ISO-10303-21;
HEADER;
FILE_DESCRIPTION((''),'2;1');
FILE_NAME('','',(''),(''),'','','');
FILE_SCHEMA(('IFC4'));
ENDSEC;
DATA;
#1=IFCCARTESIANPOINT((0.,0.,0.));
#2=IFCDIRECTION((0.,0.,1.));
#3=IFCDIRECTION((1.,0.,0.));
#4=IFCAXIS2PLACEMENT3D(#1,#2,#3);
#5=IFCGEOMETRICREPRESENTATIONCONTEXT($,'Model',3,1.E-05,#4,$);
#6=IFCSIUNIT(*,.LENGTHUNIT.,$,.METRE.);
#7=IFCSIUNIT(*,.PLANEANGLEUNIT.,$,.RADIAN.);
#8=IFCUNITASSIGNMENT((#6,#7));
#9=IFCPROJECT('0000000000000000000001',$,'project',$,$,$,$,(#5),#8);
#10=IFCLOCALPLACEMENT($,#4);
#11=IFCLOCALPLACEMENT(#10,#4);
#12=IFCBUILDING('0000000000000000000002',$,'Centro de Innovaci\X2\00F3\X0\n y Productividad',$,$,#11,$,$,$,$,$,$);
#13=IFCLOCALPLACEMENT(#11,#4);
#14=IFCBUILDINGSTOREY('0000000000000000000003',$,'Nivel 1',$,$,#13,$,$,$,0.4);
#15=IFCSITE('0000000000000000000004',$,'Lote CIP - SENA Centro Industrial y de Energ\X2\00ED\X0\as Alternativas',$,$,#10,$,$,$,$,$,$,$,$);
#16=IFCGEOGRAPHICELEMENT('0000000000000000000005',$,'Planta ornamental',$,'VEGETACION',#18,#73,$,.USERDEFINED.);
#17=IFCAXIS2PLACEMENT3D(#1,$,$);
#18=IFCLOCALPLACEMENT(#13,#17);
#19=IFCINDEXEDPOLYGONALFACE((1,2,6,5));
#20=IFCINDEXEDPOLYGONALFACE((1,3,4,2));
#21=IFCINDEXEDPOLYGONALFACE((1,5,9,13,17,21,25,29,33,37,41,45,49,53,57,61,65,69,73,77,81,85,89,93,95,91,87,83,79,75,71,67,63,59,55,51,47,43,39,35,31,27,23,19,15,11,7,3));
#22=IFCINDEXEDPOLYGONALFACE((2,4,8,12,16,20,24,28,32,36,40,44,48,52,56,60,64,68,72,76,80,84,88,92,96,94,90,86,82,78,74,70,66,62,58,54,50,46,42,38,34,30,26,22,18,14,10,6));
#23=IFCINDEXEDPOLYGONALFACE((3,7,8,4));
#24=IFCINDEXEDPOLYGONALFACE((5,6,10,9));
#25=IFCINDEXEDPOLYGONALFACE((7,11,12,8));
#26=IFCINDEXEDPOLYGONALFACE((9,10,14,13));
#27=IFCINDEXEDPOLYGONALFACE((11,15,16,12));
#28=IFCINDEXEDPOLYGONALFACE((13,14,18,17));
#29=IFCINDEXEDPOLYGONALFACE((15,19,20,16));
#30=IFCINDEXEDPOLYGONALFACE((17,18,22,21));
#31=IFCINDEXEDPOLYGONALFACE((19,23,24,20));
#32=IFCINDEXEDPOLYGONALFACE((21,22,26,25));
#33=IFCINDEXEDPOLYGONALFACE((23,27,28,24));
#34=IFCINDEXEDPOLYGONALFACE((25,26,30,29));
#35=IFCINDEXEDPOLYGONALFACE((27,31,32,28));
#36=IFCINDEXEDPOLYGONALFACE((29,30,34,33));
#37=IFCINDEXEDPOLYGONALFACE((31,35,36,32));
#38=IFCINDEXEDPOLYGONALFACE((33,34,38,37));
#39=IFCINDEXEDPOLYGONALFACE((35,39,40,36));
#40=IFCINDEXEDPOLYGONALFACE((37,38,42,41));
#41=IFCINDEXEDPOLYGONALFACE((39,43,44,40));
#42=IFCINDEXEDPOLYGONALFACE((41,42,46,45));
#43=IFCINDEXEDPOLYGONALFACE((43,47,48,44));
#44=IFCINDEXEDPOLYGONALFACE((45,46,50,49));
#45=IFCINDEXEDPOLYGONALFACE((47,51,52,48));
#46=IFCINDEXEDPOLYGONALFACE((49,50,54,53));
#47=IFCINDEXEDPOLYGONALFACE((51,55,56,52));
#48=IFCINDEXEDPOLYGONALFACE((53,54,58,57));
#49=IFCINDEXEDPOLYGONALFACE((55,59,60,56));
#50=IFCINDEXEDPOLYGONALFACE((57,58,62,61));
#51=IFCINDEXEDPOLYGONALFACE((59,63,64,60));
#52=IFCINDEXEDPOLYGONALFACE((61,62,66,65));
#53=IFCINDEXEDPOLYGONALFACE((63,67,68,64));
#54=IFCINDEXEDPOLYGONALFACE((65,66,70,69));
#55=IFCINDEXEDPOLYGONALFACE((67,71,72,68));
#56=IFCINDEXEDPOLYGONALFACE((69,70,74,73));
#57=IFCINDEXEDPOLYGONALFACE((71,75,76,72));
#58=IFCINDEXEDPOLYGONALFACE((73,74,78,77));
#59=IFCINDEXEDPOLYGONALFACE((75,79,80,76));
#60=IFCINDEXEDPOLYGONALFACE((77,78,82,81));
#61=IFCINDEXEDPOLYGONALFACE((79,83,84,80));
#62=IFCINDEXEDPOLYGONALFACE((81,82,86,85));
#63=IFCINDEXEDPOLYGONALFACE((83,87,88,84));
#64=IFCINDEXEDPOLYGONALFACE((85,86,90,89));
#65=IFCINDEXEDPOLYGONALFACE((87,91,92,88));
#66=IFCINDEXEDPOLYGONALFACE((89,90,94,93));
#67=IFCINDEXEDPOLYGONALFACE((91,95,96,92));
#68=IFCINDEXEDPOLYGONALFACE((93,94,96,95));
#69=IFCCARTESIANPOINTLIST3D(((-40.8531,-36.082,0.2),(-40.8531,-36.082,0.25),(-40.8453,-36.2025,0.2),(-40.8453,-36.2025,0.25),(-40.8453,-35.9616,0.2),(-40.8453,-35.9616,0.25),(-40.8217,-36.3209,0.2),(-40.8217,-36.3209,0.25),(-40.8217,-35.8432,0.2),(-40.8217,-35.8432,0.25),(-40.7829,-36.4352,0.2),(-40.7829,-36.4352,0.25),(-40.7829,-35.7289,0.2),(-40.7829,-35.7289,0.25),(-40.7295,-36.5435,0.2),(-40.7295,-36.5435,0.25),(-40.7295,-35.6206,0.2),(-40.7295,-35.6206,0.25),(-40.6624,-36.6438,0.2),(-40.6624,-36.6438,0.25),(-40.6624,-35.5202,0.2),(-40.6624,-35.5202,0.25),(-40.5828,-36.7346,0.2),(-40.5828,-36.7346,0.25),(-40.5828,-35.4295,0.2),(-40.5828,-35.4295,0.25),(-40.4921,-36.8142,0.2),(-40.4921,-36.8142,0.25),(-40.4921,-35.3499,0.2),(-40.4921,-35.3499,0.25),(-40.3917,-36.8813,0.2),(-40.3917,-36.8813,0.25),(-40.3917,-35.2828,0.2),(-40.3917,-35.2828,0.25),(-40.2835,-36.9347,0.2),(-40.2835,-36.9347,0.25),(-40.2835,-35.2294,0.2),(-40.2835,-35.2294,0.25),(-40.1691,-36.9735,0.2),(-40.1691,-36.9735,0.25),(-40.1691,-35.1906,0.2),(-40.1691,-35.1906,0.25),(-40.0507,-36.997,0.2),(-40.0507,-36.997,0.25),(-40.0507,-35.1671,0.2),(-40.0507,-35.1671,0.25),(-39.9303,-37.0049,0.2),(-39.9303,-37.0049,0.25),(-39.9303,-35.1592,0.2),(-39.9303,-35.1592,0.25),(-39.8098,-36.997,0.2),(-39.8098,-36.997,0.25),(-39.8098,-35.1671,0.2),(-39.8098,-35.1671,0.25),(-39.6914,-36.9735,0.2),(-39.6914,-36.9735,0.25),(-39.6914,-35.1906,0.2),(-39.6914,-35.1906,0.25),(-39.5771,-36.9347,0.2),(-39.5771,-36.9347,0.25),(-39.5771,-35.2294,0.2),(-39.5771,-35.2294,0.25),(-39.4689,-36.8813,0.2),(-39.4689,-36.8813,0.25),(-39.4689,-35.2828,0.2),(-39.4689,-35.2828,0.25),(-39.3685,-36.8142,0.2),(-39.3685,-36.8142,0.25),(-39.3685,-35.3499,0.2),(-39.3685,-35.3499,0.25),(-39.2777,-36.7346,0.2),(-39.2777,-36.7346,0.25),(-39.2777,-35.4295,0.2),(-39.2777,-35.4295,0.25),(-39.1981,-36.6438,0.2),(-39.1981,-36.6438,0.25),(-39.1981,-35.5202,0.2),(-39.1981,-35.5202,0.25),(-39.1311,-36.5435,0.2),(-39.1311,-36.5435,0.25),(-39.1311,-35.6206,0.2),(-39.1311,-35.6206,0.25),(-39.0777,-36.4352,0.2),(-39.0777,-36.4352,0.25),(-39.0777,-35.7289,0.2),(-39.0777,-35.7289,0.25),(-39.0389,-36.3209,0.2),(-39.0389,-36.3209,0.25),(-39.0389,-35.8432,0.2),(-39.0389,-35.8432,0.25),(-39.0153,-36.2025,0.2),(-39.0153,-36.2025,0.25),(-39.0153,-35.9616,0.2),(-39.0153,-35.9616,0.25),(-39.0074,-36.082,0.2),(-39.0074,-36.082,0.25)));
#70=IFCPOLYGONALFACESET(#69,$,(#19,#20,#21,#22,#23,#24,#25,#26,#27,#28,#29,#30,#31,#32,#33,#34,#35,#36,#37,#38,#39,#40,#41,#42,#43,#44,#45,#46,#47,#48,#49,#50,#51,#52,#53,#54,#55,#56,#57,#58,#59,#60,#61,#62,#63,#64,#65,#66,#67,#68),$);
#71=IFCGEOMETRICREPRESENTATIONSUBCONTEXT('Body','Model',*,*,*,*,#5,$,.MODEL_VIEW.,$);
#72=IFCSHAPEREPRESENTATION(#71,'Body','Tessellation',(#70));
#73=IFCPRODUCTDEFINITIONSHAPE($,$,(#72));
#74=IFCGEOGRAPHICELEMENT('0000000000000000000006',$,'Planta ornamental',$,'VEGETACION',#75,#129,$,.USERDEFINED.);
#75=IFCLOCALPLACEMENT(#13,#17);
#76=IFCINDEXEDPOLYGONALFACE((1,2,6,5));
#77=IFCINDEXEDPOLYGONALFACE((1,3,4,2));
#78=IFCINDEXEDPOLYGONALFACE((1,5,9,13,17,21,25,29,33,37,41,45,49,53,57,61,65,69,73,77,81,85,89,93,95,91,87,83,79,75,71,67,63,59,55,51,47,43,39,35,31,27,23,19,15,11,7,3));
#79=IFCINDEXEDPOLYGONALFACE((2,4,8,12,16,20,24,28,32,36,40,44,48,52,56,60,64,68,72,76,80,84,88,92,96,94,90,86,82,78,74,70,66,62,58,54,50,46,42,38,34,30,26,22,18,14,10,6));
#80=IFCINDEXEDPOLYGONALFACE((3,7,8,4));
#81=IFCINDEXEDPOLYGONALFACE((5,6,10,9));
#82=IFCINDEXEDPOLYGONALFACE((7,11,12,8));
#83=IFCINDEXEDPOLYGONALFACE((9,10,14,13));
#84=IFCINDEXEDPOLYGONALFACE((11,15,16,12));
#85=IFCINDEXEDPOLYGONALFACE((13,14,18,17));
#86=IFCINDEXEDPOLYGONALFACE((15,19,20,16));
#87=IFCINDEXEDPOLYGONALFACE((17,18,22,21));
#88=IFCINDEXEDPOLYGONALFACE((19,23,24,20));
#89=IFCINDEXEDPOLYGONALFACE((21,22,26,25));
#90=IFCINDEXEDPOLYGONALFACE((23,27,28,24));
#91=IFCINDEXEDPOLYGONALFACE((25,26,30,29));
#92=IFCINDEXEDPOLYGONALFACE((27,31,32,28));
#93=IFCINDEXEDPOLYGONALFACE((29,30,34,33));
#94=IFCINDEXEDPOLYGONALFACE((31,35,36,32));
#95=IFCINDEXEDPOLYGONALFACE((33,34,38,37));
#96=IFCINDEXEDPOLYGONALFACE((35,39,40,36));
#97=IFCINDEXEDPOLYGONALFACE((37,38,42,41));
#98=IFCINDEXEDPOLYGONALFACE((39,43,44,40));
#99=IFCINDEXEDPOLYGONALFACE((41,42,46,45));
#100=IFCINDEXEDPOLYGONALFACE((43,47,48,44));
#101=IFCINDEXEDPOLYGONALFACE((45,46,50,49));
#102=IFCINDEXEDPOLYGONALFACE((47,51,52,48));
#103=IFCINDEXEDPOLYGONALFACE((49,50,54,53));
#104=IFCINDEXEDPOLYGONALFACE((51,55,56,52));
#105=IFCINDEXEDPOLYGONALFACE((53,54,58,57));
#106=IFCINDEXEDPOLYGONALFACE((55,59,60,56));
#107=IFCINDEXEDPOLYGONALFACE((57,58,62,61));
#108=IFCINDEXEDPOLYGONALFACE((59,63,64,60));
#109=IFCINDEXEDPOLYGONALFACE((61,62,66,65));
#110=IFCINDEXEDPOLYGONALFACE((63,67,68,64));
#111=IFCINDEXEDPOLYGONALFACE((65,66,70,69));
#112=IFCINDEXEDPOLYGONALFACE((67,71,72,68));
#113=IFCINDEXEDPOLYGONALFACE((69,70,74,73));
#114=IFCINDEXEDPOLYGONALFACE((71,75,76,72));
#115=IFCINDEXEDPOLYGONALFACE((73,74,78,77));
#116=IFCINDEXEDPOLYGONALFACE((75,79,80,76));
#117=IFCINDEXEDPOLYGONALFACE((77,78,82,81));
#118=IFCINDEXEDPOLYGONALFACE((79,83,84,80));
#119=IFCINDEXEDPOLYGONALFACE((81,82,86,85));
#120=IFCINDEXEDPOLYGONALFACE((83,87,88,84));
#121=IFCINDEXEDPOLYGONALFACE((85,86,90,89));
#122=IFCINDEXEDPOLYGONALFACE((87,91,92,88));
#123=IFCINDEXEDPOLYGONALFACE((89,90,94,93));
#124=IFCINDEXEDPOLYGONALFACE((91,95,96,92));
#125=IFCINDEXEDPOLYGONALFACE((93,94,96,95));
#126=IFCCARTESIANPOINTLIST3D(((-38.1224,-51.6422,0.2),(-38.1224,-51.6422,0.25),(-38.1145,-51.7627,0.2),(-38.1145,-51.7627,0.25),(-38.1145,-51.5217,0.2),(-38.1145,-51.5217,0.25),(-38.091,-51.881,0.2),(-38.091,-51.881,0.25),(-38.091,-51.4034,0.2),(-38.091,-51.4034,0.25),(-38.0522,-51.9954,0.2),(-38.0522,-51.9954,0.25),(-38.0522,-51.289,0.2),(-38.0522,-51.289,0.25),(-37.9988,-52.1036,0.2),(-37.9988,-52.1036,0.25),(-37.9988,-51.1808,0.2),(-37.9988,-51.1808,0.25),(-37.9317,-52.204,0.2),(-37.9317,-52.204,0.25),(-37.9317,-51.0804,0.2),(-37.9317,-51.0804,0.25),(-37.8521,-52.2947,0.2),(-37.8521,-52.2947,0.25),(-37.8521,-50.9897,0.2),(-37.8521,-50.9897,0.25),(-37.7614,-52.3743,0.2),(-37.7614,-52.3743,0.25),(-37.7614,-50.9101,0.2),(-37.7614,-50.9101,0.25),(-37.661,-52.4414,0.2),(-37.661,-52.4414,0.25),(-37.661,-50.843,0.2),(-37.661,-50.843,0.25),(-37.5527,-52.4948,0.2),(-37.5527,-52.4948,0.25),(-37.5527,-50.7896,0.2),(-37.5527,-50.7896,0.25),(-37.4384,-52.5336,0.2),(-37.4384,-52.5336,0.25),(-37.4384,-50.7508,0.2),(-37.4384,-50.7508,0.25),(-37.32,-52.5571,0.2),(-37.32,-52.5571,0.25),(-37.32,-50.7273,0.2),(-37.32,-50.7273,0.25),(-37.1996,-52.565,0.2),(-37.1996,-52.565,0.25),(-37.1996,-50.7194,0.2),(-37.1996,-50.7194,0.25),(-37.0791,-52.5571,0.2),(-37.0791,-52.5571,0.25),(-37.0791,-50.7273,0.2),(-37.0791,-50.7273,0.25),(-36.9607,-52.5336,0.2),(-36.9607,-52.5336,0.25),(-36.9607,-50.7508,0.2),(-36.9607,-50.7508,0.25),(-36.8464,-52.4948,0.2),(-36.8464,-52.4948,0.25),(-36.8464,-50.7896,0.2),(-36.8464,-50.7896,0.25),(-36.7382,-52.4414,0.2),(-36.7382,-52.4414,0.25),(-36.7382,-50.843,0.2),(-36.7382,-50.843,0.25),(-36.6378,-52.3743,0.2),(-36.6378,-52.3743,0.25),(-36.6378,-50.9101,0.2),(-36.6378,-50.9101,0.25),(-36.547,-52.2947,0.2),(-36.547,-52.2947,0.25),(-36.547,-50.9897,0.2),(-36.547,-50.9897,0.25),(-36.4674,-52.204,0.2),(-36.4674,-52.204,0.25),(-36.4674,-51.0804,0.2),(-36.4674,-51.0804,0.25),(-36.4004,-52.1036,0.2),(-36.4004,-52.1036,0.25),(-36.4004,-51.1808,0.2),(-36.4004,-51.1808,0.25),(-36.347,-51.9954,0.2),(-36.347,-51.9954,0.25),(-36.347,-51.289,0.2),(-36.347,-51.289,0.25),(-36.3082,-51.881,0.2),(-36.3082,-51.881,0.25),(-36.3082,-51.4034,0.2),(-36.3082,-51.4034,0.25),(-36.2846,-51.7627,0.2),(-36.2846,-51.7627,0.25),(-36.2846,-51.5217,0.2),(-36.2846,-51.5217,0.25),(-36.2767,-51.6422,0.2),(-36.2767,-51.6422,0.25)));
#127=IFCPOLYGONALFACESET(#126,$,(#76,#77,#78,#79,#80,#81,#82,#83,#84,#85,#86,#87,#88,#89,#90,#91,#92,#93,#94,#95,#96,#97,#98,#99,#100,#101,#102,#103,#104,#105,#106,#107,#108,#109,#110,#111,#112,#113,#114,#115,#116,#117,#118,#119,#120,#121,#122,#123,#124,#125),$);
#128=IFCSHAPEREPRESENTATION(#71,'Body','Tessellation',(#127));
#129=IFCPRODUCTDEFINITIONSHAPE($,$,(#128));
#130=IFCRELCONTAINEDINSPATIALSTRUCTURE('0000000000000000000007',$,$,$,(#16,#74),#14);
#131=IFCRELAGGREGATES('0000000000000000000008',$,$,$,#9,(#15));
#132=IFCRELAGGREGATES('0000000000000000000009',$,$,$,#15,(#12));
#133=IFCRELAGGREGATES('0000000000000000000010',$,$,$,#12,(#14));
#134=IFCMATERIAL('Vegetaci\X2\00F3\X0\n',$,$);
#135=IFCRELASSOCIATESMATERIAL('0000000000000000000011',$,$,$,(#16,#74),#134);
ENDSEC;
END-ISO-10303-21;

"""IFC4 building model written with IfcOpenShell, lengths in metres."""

from ifc_helpers import new_model, si_unit, frame, origin_with_axes, place, context, subcontext, project, spatial, polyline, outline, extrude, material, element, save


model = new_model("IFC4")

# Units and contexts
model_context = context("Model", 3, precision=1e-05, world=origin_with_axes())
body_context = subcontext(model_context, "Body", "Model", "MODEL_VIEW")
ifc_project = project(units=[si_unit("LENGTHUNIT", "METRE"), si_unit("PLANEANGLEUNIT", "RADIAN")], contexts=[model_context])

# Site, building, storey
site_placement = place(None, origin_with_axes())
site = spatial("IfcSite", under=ifc_project, at=site_placement, Name="Lote CIP - SENA Centro Industrial y de Energías Alternativas")
building_placement = place(site_placement, origin_with_axes())
building = spatial("IfcBuilding", under=site, at=building_placement, Name="Centro de Innovación y Productividad")
storey_placement = place(building_placement, origin_with_axes())
storey = spatial("IfcBuildingStorey", under=building, at=storey_placement, Name="Nivel 1", Elevation=0.4)

# Geographic elements
ifc_material_1 = material(Name="Vegetación")
geographic_element_1_placement = place(storey_placement, origin_with_axes())
element("IfcGeographicElement", 1, at=geographic_element_1_placement, inside=storey, material=ifc_material_1, Name="Planta ornamental", ObjectType="VEGETACION", PredefinedType="USERDEFINED", context=body_context, shape_type="SweptSolid", body=[
    extrude(outline(polyline([(-39.0074, -36.082), (-39.0153, -36.2025), (-39.0389, -36.3209), (-39.0777, -36.4352), (-39.1311, -36.5435), (-39.1981, -36.6438), (-39.2777, -36.7346), (-39.3685, -36.8142), (-39.4689, -36.8813), (-39.5771, -36.9347), (-39.6914, -36.9735), (-39.8098, -36.997), (-39.9303, -37.0049), (-40.0507, -36.997), (-40.1691, -36.9735), (-40.2835, -36.9347), (-40.3917, -36.8813), (-40.4921, -36.8142), (-40.5828, -36.7346), (-40.6624, -36.6438), (-40.7295, -36.5435), (-40.7829, -36.4352), (-40.8217, -36.3209), (-40.8453, -36.2025), (-40.8531, -36.082), (-40.8453, -35.9616), (-40.8217, -35.8432), (-40.7829, -35.7289), (-40.7295, -35.6206), (-40.6624, -35.5202), (-40.5828, -35.4295), (-40.4921, -35.3499), (-40.3917, -35.2828), (-40.2835, -35.2294), (-40.1691, -35.1906), (-40.0507, -35.1671), (-39.9303, -35.1592), (-39.8098, -35.1671), (-39.6914, -35.1906), (-39.5771, -35.2294), (-39.4689, -35.2828), (-39.3685, -35.3499), (-39.2777, -35.4295), (-39.1981, -35.5202), (-39.1311, -35.6206), (-39.0777, -35.7289), (-39.0389, -35.8432), (-39.0153, -35.9616), (-39.0074, -36.082)])), frame((0.0, 0.0, 0.2)), (0.0, 0.0, 1.0), 0.05),
])
geographic_element_2_placement = place(storey_placement, origin_with_axes())
element("IfcGeographicElement", 2, at=geographic_element_2_placement, inside=storey, material=ifc_material_1, Name="Planta ornamental", ObjectType="VEGETACION", PredefinedType="USERDEFINED", context=body_context, shape_type="SweptSolid", body=[
    extrude(outline(polyline([(-36.2767, -51.6422), (-36.2846, -51.7627), (-36.3082, -51.881), (-36.347, -51.9954), (-36.4004, -52.1036), (-36.4674, -52.204), (-36.547, -52.2947), (-36.6378, -52.3743), (-36.7382, -52.4414), (-36.8464, -52.4948), (-36.9607, -52.5336), (-37.0791, -52.5571), (-37.1996, -52.565), (-37.32, -52.5571), (-37.4384, -52.5336), (-37.5527, -52.4948), (-37.661, -52.4414), (-37.7614, -52.3743), (-37.8521, -52.2947), (-37.9317, -52.204), (-37.9988, -52.1036), (-38.0522, -51.9954), (-38.091, -51.881), (-38.1145, -51.7627), (-38.1224, -51.6422), (-38.1145, -51.5217), (-38.091, -51.4034), (-38.0522, -51.289), (-37.9988, -51.1808), (-37.9317, -51.0804), (-37.8521, -50.9897), (-37.7614, -50.9101), (-37.661, -50.843), (-37.5527, -50.7896), (-37.4384, -50.7508), (-37.32, -50.7273), (-37.1996, -50.7194), (-37.0791, -50.7273), (-36.9607, -50.7508), (-36.8464, -50.7896), (-36.7382, -50.843), (-36.6378, -50.9101), (-36.547, -50.9897), (-36.4674, -51.0804), (-36.4004, -51.1808), (-36.347, -51.289), (-36.3082, -51.4034), (-36.2846, -51.5217), (-36.2767, -51.6422)])), frame((0.0, 0.0, 0.2)), (0.0, 0.0, 1.0), 0.05),
])

save(model, "model.ifc")
